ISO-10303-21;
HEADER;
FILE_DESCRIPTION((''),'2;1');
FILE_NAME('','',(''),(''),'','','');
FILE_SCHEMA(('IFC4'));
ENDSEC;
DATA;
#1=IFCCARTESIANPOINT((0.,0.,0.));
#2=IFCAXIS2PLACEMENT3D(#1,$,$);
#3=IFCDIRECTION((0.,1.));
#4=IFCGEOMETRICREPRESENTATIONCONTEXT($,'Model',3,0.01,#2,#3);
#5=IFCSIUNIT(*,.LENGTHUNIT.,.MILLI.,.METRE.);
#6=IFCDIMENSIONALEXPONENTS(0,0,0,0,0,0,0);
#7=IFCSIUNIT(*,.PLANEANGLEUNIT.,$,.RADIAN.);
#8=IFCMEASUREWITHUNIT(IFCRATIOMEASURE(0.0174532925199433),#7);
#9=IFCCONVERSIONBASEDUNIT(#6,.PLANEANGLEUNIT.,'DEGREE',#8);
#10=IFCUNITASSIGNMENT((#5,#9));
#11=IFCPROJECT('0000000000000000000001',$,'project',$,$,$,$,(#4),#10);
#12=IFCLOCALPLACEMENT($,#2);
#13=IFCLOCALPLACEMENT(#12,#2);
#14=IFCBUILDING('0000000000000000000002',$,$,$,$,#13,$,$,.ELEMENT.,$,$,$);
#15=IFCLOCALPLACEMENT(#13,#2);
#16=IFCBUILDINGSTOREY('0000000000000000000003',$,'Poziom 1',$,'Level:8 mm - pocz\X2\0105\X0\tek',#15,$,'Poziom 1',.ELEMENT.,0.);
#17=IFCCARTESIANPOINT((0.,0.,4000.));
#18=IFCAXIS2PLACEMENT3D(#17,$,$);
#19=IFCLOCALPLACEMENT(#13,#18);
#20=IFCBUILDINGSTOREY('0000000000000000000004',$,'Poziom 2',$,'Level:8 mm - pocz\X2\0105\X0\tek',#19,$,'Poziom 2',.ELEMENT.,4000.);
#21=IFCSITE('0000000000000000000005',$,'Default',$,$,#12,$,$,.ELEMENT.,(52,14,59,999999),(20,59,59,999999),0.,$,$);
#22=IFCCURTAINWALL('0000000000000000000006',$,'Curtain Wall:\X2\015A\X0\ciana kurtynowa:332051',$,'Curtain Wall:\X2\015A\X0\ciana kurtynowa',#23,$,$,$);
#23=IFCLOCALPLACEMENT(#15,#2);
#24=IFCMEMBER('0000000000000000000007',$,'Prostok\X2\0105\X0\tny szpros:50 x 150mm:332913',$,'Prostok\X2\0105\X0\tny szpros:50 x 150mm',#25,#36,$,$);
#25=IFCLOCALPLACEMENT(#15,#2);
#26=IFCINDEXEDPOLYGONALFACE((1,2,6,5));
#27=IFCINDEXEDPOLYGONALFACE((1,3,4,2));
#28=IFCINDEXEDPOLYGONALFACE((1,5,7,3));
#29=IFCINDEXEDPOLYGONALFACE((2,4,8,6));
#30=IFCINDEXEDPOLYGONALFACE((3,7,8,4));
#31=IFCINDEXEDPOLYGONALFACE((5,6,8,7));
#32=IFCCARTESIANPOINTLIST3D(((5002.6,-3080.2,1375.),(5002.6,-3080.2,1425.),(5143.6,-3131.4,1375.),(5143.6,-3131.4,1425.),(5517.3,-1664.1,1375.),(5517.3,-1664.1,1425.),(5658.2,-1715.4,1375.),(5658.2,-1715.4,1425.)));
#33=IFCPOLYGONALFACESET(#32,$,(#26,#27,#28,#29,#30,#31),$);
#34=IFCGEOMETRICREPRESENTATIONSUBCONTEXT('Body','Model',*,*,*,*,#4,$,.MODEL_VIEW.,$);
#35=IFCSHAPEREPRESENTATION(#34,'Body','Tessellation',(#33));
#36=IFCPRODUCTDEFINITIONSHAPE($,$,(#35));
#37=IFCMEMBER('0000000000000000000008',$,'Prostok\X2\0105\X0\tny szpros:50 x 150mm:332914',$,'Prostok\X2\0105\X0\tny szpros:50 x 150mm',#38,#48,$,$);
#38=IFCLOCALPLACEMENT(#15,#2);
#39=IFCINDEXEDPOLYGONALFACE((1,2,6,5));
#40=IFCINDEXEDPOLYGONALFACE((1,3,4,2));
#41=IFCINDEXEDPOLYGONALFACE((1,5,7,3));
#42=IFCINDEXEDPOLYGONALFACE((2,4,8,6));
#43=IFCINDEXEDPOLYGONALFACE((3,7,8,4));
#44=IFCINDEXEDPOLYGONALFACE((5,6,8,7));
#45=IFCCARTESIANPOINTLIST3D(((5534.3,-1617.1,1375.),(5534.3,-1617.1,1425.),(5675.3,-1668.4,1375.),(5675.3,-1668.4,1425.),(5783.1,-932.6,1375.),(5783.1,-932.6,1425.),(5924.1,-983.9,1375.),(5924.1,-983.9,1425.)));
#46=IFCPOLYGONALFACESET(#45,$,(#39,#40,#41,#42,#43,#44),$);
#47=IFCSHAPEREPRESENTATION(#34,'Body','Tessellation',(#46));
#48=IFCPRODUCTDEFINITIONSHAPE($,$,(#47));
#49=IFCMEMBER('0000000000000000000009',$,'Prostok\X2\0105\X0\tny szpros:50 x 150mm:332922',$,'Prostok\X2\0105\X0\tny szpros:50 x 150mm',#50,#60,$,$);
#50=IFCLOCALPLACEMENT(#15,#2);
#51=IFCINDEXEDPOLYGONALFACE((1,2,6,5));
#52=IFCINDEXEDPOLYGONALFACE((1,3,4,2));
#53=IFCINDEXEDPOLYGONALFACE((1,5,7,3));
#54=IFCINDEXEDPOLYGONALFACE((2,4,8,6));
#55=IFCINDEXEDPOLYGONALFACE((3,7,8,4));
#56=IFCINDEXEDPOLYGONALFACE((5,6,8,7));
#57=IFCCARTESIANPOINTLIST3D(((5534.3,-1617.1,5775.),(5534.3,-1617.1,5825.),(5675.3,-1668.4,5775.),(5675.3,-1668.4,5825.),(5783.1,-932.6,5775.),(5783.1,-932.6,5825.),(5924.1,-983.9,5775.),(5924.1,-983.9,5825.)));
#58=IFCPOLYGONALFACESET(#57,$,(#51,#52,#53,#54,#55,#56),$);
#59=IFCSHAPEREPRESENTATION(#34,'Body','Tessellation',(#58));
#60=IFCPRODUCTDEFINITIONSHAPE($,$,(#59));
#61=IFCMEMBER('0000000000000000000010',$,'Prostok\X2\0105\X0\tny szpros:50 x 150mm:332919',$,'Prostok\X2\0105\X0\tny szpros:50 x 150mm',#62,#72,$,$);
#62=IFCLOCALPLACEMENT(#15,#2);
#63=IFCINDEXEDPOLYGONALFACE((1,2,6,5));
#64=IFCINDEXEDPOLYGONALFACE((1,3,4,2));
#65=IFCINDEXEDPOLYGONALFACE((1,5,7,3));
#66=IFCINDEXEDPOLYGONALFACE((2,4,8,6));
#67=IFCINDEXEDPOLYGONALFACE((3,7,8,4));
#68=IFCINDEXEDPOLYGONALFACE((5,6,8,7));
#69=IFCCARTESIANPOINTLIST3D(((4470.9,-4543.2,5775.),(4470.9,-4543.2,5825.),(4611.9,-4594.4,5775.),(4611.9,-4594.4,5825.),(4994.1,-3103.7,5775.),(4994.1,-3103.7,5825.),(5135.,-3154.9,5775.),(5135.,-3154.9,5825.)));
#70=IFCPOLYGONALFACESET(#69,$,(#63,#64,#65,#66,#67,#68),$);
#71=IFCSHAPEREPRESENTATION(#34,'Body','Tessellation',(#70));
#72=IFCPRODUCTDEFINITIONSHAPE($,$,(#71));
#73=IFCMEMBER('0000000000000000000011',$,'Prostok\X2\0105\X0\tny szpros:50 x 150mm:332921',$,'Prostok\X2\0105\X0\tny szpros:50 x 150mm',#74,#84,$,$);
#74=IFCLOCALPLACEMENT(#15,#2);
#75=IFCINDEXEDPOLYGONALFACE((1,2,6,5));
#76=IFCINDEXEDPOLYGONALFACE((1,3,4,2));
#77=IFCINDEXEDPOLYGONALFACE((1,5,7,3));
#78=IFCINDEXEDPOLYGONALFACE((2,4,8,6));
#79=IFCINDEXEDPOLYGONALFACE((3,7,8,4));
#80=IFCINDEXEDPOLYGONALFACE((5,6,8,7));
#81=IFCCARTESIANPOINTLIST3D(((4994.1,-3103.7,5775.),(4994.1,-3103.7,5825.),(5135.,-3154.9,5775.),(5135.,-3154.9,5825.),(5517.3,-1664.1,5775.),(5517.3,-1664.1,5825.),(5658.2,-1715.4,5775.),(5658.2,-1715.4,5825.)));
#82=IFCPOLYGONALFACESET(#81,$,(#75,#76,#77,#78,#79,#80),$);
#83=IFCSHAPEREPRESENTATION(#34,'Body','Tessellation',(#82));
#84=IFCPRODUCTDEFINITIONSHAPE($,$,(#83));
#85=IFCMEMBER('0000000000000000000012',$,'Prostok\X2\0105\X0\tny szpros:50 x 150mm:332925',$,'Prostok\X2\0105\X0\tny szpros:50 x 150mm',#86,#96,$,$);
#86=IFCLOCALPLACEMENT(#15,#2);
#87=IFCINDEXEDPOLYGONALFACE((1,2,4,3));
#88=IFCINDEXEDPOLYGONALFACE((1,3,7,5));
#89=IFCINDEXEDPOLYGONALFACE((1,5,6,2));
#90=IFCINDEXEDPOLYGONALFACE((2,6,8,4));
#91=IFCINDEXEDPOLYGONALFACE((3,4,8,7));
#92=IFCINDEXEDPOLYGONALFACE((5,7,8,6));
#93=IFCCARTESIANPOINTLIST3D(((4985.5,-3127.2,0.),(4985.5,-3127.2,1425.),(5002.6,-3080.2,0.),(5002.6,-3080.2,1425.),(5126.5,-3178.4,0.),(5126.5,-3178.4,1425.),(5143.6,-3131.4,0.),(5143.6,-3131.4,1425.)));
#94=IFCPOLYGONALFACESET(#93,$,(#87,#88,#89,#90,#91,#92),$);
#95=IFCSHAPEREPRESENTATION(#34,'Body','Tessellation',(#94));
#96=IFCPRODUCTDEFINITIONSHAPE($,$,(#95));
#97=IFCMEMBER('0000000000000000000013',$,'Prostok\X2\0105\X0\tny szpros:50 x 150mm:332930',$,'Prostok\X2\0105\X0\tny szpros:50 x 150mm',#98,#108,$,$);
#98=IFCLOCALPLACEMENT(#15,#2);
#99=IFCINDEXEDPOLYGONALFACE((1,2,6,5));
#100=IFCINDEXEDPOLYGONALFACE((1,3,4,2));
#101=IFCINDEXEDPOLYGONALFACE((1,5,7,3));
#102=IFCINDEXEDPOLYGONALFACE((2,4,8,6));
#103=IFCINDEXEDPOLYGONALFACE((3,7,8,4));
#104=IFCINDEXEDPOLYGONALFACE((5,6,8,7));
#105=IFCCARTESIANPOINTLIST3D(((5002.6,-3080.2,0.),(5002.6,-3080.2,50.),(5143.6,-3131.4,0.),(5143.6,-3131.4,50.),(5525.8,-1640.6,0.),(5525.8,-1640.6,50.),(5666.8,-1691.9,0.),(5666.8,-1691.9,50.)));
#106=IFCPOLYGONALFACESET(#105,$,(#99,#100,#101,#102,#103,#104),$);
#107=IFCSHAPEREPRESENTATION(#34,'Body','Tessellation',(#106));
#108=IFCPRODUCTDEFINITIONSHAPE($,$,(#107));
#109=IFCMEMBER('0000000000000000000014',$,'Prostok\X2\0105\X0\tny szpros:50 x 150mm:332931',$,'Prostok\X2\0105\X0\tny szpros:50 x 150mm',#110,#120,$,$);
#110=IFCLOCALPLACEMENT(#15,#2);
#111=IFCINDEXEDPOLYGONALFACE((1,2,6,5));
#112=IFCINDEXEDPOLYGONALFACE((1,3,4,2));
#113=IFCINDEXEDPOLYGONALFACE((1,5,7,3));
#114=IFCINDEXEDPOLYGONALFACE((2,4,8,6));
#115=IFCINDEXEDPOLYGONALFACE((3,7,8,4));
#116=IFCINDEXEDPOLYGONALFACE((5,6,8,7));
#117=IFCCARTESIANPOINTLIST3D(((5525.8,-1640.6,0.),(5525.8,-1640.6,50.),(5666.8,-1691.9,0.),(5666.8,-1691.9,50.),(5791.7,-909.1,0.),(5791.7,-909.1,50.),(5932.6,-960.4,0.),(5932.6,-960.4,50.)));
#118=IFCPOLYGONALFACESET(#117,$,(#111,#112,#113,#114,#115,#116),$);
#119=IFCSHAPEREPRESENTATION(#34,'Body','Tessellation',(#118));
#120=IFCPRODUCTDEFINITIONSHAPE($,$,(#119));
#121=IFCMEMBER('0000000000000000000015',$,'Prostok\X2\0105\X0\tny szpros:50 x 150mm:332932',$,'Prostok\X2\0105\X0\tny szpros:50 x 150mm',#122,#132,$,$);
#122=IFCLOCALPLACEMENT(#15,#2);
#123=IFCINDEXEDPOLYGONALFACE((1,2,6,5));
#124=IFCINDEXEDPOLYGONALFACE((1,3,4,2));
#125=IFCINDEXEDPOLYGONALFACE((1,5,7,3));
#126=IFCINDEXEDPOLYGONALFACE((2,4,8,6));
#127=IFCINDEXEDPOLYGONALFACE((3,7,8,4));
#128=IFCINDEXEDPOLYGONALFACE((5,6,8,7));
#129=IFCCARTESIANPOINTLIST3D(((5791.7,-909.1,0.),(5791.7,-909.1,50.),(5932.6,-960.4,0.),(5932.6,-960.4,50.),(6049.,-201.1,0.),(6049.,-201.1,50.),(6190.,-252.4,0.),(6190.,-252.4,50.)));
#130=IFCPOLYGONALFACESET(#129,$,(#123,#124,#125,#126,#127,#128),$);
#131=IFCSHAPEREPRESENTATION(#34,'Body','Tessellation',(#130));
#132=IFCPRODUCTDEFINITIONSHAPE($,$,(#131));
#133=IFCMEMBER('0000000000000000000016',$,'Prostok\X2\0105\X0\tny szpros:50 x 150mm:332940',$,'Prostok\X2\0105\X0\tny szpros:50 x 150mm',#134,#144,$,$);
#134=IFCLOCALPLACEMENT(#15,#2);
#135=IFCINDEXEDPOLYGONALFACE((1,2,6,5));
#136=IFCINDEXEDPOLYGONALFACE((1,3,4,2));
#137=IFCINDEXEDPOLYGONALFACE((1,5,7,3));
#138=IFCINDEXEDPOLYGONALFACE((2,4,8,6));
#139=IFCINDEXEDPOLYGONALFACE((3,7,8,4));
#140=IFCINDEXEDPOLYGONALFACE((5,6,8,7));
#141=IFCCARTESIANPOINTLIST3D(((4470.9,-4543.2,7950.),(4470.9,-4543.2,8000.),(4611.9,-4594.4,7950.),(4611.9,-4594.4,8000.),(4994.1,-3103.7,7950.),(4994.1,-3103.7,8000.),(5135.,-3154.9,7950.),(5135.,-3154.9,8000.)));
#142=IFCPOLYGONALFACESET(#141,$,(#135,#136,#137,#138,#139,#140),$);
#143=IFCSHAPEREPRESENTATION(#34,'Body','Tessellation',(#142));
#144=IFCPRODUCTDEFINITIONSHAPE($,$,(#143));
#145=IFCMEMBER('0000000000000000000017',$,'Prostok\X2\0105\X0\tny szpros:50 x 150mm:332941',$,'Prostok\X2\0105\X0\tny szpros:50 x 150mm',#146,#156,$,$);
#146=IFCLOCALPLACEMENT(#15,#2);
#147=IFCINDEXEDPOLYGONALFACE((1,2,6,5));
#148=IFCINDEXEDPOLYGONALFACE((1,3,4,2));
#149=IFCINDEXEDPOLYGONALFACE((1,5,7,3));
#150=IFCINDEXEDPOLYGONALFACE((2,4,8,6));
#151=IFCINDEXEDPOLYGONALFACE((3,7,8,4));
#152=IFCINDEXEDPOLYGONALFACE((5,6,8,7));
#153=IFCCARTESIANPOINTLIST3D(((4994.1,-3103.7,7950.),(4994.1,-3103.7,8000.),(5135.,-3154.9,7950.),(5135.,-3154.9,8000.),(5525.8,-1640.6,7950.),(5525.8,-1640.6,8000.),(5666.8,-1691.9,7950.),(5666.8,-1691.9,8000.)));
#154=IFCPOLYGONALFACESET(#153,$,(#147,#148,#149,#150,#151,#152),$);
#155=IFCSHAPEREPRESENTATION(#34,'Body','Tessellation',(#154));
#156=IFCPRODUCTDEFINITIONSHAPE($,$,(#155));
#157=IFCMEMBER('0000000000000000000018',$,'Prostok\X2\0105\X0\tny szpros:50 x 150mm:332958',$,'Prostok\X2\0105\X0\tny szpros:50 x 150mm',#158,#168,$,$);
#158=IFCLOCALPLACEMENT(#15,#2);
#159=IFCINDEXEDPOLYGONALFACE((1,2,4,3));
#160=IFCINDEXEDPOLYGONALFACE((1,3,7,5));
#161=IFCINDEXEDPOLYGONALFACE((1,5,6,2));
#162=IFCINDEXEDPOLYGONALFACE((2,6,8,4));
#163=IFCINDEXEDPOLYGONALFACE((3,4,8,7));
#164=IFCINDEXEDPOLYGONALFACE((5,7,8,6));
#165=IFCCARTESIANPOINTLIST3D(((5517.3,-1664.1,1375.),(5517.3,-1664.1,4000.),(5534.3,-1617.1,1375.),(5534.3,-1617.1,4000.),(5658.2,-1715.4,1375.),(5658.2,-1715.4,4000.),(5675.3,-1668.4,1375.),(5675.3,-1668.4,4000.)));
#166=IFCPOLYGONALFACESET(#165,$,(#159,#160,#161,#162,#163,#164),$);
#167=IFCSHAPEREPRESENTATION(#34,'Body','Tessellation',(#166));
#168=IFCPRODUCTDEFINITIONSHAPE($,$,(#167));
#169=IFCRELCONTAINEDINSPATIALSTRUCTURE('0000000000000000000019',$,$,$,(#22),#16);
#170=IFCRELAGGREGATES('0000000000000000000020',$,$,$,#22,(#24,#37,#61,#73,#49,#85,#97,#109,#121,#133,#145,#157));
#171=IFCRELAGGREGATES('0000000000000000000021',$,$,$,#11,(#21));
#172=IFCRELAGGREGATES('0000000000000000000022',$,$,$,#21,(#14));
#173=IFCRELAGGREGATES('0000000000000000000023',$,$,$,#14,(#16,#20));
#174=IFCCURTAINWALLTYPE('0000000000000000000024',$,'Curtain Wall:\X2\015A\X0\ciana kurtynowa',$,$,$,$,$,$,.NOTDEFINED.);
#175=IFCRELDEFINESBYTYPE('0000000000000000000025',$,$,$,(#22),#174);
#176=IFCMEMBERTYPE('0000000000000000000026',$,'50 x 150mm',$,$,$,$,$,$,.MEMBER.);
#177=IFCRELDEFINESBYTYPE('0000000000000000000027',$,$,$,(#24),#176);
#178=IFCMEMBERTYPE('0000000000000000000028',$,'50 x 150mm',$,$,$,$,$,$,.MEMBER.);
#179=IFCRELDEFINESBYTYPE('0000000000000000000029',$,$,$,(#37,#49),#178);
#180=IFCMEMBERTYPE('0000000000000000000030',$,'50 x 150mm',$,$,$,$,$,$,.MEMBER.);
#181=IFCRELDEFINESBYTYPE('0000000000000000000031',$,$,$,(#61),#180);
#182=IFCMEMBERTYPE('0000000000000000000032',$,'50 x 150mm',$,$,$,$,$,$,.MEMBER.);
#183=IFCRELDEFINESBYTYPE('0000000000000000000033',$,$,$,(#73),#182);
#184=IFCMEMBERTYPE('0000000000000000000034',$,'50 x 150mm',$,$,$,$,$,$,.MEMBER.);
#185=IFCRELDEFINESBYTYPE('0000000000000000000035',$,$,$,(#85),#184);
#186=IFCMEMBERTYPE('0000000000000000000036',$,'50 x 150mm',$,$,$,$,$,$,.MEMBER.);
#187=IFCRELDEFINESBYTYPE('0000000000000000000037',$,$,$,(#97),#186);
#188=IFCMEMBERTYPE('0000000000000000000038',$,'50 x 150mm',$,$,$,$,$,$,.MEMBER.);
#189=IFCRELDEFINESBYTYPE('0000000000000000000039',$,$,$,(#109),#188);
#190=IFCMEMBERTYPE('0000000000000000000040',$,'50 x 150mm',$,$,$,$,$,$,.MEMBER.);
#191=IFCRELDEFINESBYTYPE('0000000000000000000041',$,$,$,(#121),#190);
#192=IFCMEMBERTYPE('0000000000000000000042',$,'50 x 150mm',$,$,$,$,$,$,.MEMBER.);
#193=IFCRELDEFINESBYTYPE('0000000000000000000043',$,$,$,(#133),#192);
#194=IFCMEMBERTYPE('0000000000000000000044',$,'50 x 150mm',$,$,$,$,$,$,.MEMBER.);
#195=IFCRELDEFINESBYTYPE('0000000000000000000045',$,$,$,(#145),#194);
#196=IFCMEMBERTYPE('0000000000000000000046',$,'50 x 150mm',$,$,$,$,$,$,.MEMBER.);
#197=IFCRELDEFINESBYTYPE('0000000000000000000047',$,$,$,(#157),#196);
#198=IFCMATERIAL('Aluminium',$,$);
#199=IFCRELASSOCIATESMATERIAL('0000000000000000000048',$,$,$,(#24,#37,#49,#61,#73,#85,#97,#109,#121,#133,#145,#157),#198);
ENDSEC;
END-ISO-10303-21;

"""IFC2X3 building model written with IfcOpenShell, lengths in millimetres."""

from ifc_helpers import new_model, entity, si_unit, converted_unit, direction, frame, origin, origin_2d_with_axis, place, context, subcontext, project, spatial, rectangle, extrude, source, transform, mapped, material, type_object, type_shapes, element, aggregate, save


model = new_model("IFC2X3")

# Units and contexts
model_context = context("Model", 3, precision=0.01, world=origin(), true_north=direction((0.0, 1.0)))
body_context = subcontext(model_context, "Body", "Model", "MODEL_VIEW")
ifc_project = project(units=[si_unit("LENGTHUNIT", "METRE", prefix="MILLI"), converted_unit("PLANEANGLEUNIT", "DEGREE", entity("IfcRatioMeasure", 0.0174532925199433), si_unit("PLANEANGLEUNIT", "RADIAN"), dimensions=[0, 0, 0, 0, 0, 0, 0])], contexts=[model_context])

# Site, building, storey
site_placement = place(None, origin())
site = spatial("IfcSite", under=ifc_project, at=site_placement, Name="Default", CompositionType="ELEMENT", RefLatitude=(52, 14, 59, 999999), RefLongitude=(20, 59, 59, 999999), RefElevation=0.0)
building_placement = place(site_placement, origin())
building = spatial("IfcBuilding", under=site, at=building_placement, CompositionType="ELEMENT")
storey_1_placement = place(building_placement, origin())
storey_1 = spatial("IfcBuildingStorey", under=building, at=storey_1_placement, Name="Poziom 1", ObjectType="Level:8 mm - początek", LongName="Poziom 1", CompositionType="ELEMENT", Elevation=0.0)

# Curtain wall, members
curtain_wall_type = type_object("IfcCurtainWallType", Name="Curtain Wall:Ściana kurtynowa", PredefinedType="NOTDEFINED")
curtain_wall_placement = place(storey_1_placement, origin())
curtain_wall = element("IfcCurtainWall", 1, at=curtain_wall_placement, inside=storey_1, type_object=curtain_wall_type, Name="Curtain Wall:Ściana kurtynowa:332051", ObjectType="Curtain Wall:Ściana kurtynowa")
ifc_material_1 = material(Name="Aluminium")
member_type_1 = type_object("IfcMemberType", Name="50 x 150mm", PredefinedType="MEMBER")
shared_shape_1 = source(origin(), body_context, "Body", "SweptSolid", [
    extrude(rectangle(XDim=150.0, YDim=50.0, at=origin_2d_with_axis()), frame((0.0, 0.0, -1506.6), z_axis=(0.0, 0.0, 1.0), x_axis=(0.0, -1.0, 0.0)), (0.0, 0.0, 1.0), 1506.6),
])
type_shapes(member_type_1, [shared_shape_1])
member_1_placement = place(storey_1_placement, frame((5587.7, -1689.8, 1400.0), z_axis=(0.341586, 0.939851, 0.0), x_axis=(0.0, 0.0, 1.0)))
member_1 = element("IfcMember", 2, at=member_1_placement, type_object=member_type_1, material=ifc_material_1, Name="Prostokątny szpros:50 x 150mm:332913", ObjectType="Prostokątny szpros:50 x 150mm", context=body_context, shape_type="MappedRepresentation", body=[
    mapped(shared_shape_1, transform((0.0, 0.0, 0.0), scale=1.0)),
])
member_type_2 = type_object("IfcMemberType", Name="50 x 150mm", PredefinedType="MEMBER")
shared_shape_2 = source(origin(), body_context, "Body", "SweptSolid", [
    extrude(rectangle(XDim=150.0, YDim=50.0, at=origin_2d_with_axis()), frame((0.0, 0.0, -728.3), z_axis=(0.0, 0.0, 1.0), x_axis=(0.0, -1.0, 0.0)), (0.0, 0.0, 1.0), 728.3),
])
type_shapes(member_type_2, [shared_shape_2])
member_2_placement = place(storey_1_placement, frame((5853.6, -958.2, 1400.0), z_axis=(0.341586, 0.939851, 0.0), x_axis=(0.0, 0.0, 1.0)))
member_2 = element("IfcMember", 3, at=member_2_placement, type_object=member_type_2, material=ifc_material_1, Name="Prostokątny szpros:50 x 150mm:332914", ObjectType="Prostokątny szpros:50 x 150mm", context=body_context, shape_type="MappedRepresentation", body=[
    mapped(shared_shape_2, transform((0.0, 0.0, 0.0), scale=1.0)),
])
member_3_placement = place(storey_1_placement, frame((5853.6, -958.2, 5800.0), z_axis=(0.341586, 0.939851, 0.0), x_axis=(0.0, 0.0, 1.0)))
member_3 = element("IfcMember", 4, at=member_3_placement, type_object=member_type_2, material=ifc_material_1, Name="Prostokątny szpros:50 x 150mm:332922", ObjectType="Prostokątny szpros:50 x 150mm", context=body_context, shape_type="MappedRepresentation", body=[
    mapped(shared_shape_2, transform((0.0, 0.0, 0.0), scale=1.0)),
])
member_type_3 = type_object("IfcMemberType", Name="50 x 150mm", PredefinedType="MEMBER")
shared_shape_3 = source(origin(), body_context, "Body", "SweptSolid", [
    extrude(rectangle(XDim=150.0, YDim=50.0, at=origin_2d_with_axis()), frame((0.0, 0.0, -1531.6), z_axis=(0.0, 0.0, 1.0), x_axis=(0.0, -1.0, 0.0)), (0.0, 0.0, 1.0), 1531.6),
])
type_shapes(member_type_3, [shared_shape_3])
member_4_placement = place(storey_1_placement, frame((5064.6, -3129.3, 5800.0), z_axis=(0.341586, 0.939851, 0.0), x_axis=(0.0, 0.0, 1.0)))
member_4 = element("IfcMember", 5, at=member_4_placement, type_object=member_type_3, material=ifc_material_1, Name="Prostokątny szpros:50 x 150mm:332919", ObjectType="Prostokątny szpros:50 x 150mm", context=body_context, shape_type="MappedRepresentation", body=[
    mapped(shared_shape_3, transform((0.0, 0.0, 0.0), scale=1.0)),
])
member_type_4 = type_object("IfcMemberType", Name="50 x 150mm", PredefinedType="MEMBER")
shared_shape_4 = source(origin(), body_context, "Body", "SweptSolid", [
    extrude(rectangle(XDim=150.0, YDim=50.0, at=origin_2d_with_axis()), frame((0.0, 0.0, -1531.6), z_axis=(0.0, 0.0, 1.0), x_axis=(0.0, -1.0, 0.0)), (0.0, 0.0, 1.0), 1531.6),
])
type_shapes(member_type_4, [shared_shape_4])
member_5_placement = place(storey_1_placement, frame((5587.7, -1689.8, 5800.0), z_axis=(0.341586, 0.939851, 0.0), x_axis=(0.0, 0.0, 1.0)))
member_5 = element("IfcMember", 6, at=member_5_placement, type_object=member_type_4, material=ifc_material_1, Name="Prostokątny szpros:50 x 150mm:332921", ObjectType="Prostokątny szpros:50 x 150mm", context=body_context, shape_type="MappedRepresentation", body=[
    mapped(shared_shape_4, transform((0.0, 0.0, 0.0), scale=1.0)),
])
member_type_5 = type_object("IfcMemberType", Name="50 x 150mm", PredefinedType="MEMBER")
shared_shape_5 = source(origin(), body_context, "Body", "SweptSolid", [
    extrude(rectangle(XDim=150.0, YDim=50.0, at=origin_2d_with_axis()), frame((0.0, 0.0, -1425.0), z_axis=(0.0, 0.0, 1.0), x_axis=(0.0, -1.0, 0.0)), (0.0, 0.0, 1.0), 1425.0),
])
type_shapes(member_type_5, [shared_shape_5])
member_6_placement = place(storey_1_placement, frame((5064.6, -3129.3, 0.0), z_axis=(0.0, 0.0, -1.0), x_axis=(0.341586, 0.939851, 0.0)))
member_6 = element("IfcMember", 7, at=member_6_placement, type_object=member_type_5, material=ifc_material_1, Name="Prostokątny szpros:50 x 150mm:332925", ObjectType="Prostokątny szpros:50 x 150mm", context=body_context, shape_type="MappedRepresentation", body=[
    mapped(shared_shape_5, transform((0.0, 0.0, 0.0), scale=1.0)),
])
member_type_6 = type_object("IfcMemberType", Name="50 x 150mm", PredefinedType="MEMBER")
shared_shape_6 = source(origin(), body_context, "Body", "SweptSolid", [
    extrude(rectangle(XDim=150.0, YDim=50.0, at=origin_2d_with_axis()), frame((-25.0, 0.0, -1531.6), z_axis=(0.0, 0.0, 1.0), x_axis=(0.0, -1.0, 0.0)), (0.0, 0.0, 1.0), 1531.6),
])
type_shapes(member_type_6, [shared_shape_6])
member_7_placement = place(storey_1_placement, frame((5073.1, -3105.8, 0.0), z_axis=(-0.341586, -0.939851, 0.0), x_axis=(0.0, 0.0, -1.0)))
member_7 = element("IfcMember", 8, at=member_7_placement, type_object=member_type_6, material=ifc_material_1, Name="Prostokątny szpros:50 x 150mm:332930", ObjectType="Prostokątny szpros:50 x 150mm", context=body_context, shape_type="MappedRepresentation", body=[
    mapped(shared_shape_6, transform((0.0, 0.0, 0.0), scale=1.0)),
])
member_type_7 = type_object("IfcMemberType", Name="50 x 150mm", PredefinedType="MEMBER")
shared_shape_7 = source(origin(), body_context, "Body", "SweptSolid", [
    extrude(rectangle(XDim=150.0, YDim=50.0, at=origin_2d_with_axis()), frame((-25.0, 0.0, -778.3), z_axis=(0.0, 0.0, 1.0), x_axis=(0.0, -1.0, 0.0)), (0.0, 0.0, 1.0), 778.3),
])
type_shapes(member_type_7, [shared_shape_7])
member_8_placement = place(storey_1_placement, frame((5596.3, -1666.3, 0.0), z_axis=(-0.341586, -0.939851, 0.0), x_axis=(0.0, 0.0, -1.0)))
member_8 = element("IfcMember", 9, at=member_8_placement, type_object=member_type_7, material=ifc_material_1, Name="Prostokątny szpros:50 x 150mm:332931", ObjectType="Prostokątny szpros:50 x 150mm", context=body_context, shape_type="MappedRepresentation", body=[
    mapped(shared_shape_7, transform((0.0, 0.0, 0.0), scale=1.0)),
])
member_type_8 = type_object("IfcMemberType", Name="50 x 150mm", PredefinedType="MEMBER")
shared_shape_8 = source(origin(), body_context, "Body", "SweptSolid", [
    extrude(rectangle(XDim=150.0, YDim=50.0, at=origin_2d_with_axis()), frame((-25.0, 0.0, -753.3), z_axis=(0.0, 0.0, 1.0), x_axis=(0.0, -1.0, 0.0)), (0.0, 0.0, 1.0), 753.3),
])
type_shapes(member_type_8, [shared_shape_8])
member_9_placement = place(storey_1_placement, frame((5862.1, -934.8, 0.0), z_axis=(-0.341586, -0.939851, 0.0), x_axis=(0.0, 0.0, -1.0)))
member_9 = element("IfcMember", 10, at=member_9_placement, type_object=member_type_8, material=ifc_material_1, Name="Prostokątny szpros:50 x 150mm:332932", ObjectType="Prostokątny szpros:50 x 150mm", context=body_context, shape_type="MappedRepresentation", body=[
    mapped(shared_shape_8, transform((0.0, 0.0, 0.0), scale=1.0)),
])
member_type_9 = type_object("IfcMemberType", Name="50 x 150mm", PredefinedType="MEMBER")
shared_shape_9 = source(origin(), body_context, "Body", "SweptSolid", [
    extrude(rectangle(XDim=150.0, YDim=50.0, at=origin_2d_with_axis()), frame((-25.0, 0.0, -1531.6), z_axis=(0.0, 0.0, 1.0), x_axis=(0.0, -1.0, 0.0)), (0.0, 0.0, 1.0), 1531.6),
])
type_shapes(member_type_9, [shared_shape_9])
member_10_placement = place(storey_1_placement, frame((5064.6, -3129.3, 8000.0), z_axis=(0.341586, 0.939851, 0.0), x_axis=(0.0, 0.0, 1.0)))
member_10 = element("IfcMember", 11, at=member_10_placement, type_object=member_type_9, material=ifc_material_1, Name="Prostokątny szpros:50 x 150mm:332940", ObjectType="Prostokątny szpros:50 x 150mm", context=body_context, shape_type="MappedRepresentation", body=[
    mapped(shared_shape_9, transform((0.0, 0.0, 0.0), scale=1.0)),
])
member_type_10 = type_object("IfcMemberType", Name="50 x 150mm", PredefinedType="MEMBER")
shared_shape_10 = source(origin(), body_context, "Body", "SweptSolid", [
    extrude(rectangle(XDim=150.0, YDim=50.0, at=origin_2d_with_axis()), frame((-25.0, 0.0, -1556.6), z_axis=(0.0, 0.0, 1.0), x_axis=(0.0, -1.0, 0.0)), (0.0, 0.0, 1.0), 1556.6),
])
type_shapes(member_type_10, [shared_shape_10])
member_11_placement = place(storey_1_placement, frame((5596.3, -1666.3, 8000.0), z_axis=(0.341586, 0.939851, 0.0), x_axis=(0.0, 0.0, 1.0)))
member_11 = element("IfcMember", 12, at=member_11_placement, type_object=member_type_10, material=ifc_material_1, Name="Prostokątny szpros:50 x 150mm:332941", ObjectType="Prostokątny szpros:50 x 150mm", context=body_context, shape_type="MappedRepresentation", body=[
    mapped(shared_shape_10, transform((0.0, 0.0, 0.0), scale=1.0)),
])
member_type_11 = type_object("IfcMemberType", Name="50 x 150mm", PredefinedType="MEMBER")
shared_shape_11 = source(origin(), body_context, "Body", "SweptSolid", [
    extrude(rectangle(XDim=150.0, YDim=50.0, at=origin_2d_with_axis()), frame((0.0, 0.0, -2625.0), z_axis=(0.0, 0.0, 1.0), x_axis=(0.0, -1.0, 0.0)), (0.0, 0.0, 1.0), 2625.0),
])
type_shapes(member_type_11, [shared_shape_11])
member_12_placement = place(storey_1_placement, frame((5596.3, -1666.3, 1375.0), z_axis=(0.0, 0.0, -1.0), x_axis=(0.341586, 0.939851, 0.0)))
member_12 = element("IfcMember", 13, at=member_12_placement, type_object=member_type_11, material=ifc_material_1, Name="Prostokątny szpros:50 x 150mm:332958", ObjectType="Prostokątny szpros:50 x 150mm", context=body_context, shape_type="MappedRepresentation", body=[
    mapped(shared_shape_11, transform((0.0, 0.0, 0.0), scale=1.0)),
])

aggregate(curtain_wall, [member_1, member_2, member_4, member_5, member_3, member_6, member_7, member_8, member_9, member_10, member_11, member_12])

# Shared definitions
storey_2_placement = place(building_placement, frame((0.0, 0.0, 4000.0)))
storey_2 = spatial("IfcBuildingStorey", under=building, at=storey_2_placement, Name="Poziom 2", ObjectType="Level:8 mm - początek", LongName="Poziom 2", CompositionType="ELEMENT", Elevation=4000.0)

save(model, "model.ifc")
